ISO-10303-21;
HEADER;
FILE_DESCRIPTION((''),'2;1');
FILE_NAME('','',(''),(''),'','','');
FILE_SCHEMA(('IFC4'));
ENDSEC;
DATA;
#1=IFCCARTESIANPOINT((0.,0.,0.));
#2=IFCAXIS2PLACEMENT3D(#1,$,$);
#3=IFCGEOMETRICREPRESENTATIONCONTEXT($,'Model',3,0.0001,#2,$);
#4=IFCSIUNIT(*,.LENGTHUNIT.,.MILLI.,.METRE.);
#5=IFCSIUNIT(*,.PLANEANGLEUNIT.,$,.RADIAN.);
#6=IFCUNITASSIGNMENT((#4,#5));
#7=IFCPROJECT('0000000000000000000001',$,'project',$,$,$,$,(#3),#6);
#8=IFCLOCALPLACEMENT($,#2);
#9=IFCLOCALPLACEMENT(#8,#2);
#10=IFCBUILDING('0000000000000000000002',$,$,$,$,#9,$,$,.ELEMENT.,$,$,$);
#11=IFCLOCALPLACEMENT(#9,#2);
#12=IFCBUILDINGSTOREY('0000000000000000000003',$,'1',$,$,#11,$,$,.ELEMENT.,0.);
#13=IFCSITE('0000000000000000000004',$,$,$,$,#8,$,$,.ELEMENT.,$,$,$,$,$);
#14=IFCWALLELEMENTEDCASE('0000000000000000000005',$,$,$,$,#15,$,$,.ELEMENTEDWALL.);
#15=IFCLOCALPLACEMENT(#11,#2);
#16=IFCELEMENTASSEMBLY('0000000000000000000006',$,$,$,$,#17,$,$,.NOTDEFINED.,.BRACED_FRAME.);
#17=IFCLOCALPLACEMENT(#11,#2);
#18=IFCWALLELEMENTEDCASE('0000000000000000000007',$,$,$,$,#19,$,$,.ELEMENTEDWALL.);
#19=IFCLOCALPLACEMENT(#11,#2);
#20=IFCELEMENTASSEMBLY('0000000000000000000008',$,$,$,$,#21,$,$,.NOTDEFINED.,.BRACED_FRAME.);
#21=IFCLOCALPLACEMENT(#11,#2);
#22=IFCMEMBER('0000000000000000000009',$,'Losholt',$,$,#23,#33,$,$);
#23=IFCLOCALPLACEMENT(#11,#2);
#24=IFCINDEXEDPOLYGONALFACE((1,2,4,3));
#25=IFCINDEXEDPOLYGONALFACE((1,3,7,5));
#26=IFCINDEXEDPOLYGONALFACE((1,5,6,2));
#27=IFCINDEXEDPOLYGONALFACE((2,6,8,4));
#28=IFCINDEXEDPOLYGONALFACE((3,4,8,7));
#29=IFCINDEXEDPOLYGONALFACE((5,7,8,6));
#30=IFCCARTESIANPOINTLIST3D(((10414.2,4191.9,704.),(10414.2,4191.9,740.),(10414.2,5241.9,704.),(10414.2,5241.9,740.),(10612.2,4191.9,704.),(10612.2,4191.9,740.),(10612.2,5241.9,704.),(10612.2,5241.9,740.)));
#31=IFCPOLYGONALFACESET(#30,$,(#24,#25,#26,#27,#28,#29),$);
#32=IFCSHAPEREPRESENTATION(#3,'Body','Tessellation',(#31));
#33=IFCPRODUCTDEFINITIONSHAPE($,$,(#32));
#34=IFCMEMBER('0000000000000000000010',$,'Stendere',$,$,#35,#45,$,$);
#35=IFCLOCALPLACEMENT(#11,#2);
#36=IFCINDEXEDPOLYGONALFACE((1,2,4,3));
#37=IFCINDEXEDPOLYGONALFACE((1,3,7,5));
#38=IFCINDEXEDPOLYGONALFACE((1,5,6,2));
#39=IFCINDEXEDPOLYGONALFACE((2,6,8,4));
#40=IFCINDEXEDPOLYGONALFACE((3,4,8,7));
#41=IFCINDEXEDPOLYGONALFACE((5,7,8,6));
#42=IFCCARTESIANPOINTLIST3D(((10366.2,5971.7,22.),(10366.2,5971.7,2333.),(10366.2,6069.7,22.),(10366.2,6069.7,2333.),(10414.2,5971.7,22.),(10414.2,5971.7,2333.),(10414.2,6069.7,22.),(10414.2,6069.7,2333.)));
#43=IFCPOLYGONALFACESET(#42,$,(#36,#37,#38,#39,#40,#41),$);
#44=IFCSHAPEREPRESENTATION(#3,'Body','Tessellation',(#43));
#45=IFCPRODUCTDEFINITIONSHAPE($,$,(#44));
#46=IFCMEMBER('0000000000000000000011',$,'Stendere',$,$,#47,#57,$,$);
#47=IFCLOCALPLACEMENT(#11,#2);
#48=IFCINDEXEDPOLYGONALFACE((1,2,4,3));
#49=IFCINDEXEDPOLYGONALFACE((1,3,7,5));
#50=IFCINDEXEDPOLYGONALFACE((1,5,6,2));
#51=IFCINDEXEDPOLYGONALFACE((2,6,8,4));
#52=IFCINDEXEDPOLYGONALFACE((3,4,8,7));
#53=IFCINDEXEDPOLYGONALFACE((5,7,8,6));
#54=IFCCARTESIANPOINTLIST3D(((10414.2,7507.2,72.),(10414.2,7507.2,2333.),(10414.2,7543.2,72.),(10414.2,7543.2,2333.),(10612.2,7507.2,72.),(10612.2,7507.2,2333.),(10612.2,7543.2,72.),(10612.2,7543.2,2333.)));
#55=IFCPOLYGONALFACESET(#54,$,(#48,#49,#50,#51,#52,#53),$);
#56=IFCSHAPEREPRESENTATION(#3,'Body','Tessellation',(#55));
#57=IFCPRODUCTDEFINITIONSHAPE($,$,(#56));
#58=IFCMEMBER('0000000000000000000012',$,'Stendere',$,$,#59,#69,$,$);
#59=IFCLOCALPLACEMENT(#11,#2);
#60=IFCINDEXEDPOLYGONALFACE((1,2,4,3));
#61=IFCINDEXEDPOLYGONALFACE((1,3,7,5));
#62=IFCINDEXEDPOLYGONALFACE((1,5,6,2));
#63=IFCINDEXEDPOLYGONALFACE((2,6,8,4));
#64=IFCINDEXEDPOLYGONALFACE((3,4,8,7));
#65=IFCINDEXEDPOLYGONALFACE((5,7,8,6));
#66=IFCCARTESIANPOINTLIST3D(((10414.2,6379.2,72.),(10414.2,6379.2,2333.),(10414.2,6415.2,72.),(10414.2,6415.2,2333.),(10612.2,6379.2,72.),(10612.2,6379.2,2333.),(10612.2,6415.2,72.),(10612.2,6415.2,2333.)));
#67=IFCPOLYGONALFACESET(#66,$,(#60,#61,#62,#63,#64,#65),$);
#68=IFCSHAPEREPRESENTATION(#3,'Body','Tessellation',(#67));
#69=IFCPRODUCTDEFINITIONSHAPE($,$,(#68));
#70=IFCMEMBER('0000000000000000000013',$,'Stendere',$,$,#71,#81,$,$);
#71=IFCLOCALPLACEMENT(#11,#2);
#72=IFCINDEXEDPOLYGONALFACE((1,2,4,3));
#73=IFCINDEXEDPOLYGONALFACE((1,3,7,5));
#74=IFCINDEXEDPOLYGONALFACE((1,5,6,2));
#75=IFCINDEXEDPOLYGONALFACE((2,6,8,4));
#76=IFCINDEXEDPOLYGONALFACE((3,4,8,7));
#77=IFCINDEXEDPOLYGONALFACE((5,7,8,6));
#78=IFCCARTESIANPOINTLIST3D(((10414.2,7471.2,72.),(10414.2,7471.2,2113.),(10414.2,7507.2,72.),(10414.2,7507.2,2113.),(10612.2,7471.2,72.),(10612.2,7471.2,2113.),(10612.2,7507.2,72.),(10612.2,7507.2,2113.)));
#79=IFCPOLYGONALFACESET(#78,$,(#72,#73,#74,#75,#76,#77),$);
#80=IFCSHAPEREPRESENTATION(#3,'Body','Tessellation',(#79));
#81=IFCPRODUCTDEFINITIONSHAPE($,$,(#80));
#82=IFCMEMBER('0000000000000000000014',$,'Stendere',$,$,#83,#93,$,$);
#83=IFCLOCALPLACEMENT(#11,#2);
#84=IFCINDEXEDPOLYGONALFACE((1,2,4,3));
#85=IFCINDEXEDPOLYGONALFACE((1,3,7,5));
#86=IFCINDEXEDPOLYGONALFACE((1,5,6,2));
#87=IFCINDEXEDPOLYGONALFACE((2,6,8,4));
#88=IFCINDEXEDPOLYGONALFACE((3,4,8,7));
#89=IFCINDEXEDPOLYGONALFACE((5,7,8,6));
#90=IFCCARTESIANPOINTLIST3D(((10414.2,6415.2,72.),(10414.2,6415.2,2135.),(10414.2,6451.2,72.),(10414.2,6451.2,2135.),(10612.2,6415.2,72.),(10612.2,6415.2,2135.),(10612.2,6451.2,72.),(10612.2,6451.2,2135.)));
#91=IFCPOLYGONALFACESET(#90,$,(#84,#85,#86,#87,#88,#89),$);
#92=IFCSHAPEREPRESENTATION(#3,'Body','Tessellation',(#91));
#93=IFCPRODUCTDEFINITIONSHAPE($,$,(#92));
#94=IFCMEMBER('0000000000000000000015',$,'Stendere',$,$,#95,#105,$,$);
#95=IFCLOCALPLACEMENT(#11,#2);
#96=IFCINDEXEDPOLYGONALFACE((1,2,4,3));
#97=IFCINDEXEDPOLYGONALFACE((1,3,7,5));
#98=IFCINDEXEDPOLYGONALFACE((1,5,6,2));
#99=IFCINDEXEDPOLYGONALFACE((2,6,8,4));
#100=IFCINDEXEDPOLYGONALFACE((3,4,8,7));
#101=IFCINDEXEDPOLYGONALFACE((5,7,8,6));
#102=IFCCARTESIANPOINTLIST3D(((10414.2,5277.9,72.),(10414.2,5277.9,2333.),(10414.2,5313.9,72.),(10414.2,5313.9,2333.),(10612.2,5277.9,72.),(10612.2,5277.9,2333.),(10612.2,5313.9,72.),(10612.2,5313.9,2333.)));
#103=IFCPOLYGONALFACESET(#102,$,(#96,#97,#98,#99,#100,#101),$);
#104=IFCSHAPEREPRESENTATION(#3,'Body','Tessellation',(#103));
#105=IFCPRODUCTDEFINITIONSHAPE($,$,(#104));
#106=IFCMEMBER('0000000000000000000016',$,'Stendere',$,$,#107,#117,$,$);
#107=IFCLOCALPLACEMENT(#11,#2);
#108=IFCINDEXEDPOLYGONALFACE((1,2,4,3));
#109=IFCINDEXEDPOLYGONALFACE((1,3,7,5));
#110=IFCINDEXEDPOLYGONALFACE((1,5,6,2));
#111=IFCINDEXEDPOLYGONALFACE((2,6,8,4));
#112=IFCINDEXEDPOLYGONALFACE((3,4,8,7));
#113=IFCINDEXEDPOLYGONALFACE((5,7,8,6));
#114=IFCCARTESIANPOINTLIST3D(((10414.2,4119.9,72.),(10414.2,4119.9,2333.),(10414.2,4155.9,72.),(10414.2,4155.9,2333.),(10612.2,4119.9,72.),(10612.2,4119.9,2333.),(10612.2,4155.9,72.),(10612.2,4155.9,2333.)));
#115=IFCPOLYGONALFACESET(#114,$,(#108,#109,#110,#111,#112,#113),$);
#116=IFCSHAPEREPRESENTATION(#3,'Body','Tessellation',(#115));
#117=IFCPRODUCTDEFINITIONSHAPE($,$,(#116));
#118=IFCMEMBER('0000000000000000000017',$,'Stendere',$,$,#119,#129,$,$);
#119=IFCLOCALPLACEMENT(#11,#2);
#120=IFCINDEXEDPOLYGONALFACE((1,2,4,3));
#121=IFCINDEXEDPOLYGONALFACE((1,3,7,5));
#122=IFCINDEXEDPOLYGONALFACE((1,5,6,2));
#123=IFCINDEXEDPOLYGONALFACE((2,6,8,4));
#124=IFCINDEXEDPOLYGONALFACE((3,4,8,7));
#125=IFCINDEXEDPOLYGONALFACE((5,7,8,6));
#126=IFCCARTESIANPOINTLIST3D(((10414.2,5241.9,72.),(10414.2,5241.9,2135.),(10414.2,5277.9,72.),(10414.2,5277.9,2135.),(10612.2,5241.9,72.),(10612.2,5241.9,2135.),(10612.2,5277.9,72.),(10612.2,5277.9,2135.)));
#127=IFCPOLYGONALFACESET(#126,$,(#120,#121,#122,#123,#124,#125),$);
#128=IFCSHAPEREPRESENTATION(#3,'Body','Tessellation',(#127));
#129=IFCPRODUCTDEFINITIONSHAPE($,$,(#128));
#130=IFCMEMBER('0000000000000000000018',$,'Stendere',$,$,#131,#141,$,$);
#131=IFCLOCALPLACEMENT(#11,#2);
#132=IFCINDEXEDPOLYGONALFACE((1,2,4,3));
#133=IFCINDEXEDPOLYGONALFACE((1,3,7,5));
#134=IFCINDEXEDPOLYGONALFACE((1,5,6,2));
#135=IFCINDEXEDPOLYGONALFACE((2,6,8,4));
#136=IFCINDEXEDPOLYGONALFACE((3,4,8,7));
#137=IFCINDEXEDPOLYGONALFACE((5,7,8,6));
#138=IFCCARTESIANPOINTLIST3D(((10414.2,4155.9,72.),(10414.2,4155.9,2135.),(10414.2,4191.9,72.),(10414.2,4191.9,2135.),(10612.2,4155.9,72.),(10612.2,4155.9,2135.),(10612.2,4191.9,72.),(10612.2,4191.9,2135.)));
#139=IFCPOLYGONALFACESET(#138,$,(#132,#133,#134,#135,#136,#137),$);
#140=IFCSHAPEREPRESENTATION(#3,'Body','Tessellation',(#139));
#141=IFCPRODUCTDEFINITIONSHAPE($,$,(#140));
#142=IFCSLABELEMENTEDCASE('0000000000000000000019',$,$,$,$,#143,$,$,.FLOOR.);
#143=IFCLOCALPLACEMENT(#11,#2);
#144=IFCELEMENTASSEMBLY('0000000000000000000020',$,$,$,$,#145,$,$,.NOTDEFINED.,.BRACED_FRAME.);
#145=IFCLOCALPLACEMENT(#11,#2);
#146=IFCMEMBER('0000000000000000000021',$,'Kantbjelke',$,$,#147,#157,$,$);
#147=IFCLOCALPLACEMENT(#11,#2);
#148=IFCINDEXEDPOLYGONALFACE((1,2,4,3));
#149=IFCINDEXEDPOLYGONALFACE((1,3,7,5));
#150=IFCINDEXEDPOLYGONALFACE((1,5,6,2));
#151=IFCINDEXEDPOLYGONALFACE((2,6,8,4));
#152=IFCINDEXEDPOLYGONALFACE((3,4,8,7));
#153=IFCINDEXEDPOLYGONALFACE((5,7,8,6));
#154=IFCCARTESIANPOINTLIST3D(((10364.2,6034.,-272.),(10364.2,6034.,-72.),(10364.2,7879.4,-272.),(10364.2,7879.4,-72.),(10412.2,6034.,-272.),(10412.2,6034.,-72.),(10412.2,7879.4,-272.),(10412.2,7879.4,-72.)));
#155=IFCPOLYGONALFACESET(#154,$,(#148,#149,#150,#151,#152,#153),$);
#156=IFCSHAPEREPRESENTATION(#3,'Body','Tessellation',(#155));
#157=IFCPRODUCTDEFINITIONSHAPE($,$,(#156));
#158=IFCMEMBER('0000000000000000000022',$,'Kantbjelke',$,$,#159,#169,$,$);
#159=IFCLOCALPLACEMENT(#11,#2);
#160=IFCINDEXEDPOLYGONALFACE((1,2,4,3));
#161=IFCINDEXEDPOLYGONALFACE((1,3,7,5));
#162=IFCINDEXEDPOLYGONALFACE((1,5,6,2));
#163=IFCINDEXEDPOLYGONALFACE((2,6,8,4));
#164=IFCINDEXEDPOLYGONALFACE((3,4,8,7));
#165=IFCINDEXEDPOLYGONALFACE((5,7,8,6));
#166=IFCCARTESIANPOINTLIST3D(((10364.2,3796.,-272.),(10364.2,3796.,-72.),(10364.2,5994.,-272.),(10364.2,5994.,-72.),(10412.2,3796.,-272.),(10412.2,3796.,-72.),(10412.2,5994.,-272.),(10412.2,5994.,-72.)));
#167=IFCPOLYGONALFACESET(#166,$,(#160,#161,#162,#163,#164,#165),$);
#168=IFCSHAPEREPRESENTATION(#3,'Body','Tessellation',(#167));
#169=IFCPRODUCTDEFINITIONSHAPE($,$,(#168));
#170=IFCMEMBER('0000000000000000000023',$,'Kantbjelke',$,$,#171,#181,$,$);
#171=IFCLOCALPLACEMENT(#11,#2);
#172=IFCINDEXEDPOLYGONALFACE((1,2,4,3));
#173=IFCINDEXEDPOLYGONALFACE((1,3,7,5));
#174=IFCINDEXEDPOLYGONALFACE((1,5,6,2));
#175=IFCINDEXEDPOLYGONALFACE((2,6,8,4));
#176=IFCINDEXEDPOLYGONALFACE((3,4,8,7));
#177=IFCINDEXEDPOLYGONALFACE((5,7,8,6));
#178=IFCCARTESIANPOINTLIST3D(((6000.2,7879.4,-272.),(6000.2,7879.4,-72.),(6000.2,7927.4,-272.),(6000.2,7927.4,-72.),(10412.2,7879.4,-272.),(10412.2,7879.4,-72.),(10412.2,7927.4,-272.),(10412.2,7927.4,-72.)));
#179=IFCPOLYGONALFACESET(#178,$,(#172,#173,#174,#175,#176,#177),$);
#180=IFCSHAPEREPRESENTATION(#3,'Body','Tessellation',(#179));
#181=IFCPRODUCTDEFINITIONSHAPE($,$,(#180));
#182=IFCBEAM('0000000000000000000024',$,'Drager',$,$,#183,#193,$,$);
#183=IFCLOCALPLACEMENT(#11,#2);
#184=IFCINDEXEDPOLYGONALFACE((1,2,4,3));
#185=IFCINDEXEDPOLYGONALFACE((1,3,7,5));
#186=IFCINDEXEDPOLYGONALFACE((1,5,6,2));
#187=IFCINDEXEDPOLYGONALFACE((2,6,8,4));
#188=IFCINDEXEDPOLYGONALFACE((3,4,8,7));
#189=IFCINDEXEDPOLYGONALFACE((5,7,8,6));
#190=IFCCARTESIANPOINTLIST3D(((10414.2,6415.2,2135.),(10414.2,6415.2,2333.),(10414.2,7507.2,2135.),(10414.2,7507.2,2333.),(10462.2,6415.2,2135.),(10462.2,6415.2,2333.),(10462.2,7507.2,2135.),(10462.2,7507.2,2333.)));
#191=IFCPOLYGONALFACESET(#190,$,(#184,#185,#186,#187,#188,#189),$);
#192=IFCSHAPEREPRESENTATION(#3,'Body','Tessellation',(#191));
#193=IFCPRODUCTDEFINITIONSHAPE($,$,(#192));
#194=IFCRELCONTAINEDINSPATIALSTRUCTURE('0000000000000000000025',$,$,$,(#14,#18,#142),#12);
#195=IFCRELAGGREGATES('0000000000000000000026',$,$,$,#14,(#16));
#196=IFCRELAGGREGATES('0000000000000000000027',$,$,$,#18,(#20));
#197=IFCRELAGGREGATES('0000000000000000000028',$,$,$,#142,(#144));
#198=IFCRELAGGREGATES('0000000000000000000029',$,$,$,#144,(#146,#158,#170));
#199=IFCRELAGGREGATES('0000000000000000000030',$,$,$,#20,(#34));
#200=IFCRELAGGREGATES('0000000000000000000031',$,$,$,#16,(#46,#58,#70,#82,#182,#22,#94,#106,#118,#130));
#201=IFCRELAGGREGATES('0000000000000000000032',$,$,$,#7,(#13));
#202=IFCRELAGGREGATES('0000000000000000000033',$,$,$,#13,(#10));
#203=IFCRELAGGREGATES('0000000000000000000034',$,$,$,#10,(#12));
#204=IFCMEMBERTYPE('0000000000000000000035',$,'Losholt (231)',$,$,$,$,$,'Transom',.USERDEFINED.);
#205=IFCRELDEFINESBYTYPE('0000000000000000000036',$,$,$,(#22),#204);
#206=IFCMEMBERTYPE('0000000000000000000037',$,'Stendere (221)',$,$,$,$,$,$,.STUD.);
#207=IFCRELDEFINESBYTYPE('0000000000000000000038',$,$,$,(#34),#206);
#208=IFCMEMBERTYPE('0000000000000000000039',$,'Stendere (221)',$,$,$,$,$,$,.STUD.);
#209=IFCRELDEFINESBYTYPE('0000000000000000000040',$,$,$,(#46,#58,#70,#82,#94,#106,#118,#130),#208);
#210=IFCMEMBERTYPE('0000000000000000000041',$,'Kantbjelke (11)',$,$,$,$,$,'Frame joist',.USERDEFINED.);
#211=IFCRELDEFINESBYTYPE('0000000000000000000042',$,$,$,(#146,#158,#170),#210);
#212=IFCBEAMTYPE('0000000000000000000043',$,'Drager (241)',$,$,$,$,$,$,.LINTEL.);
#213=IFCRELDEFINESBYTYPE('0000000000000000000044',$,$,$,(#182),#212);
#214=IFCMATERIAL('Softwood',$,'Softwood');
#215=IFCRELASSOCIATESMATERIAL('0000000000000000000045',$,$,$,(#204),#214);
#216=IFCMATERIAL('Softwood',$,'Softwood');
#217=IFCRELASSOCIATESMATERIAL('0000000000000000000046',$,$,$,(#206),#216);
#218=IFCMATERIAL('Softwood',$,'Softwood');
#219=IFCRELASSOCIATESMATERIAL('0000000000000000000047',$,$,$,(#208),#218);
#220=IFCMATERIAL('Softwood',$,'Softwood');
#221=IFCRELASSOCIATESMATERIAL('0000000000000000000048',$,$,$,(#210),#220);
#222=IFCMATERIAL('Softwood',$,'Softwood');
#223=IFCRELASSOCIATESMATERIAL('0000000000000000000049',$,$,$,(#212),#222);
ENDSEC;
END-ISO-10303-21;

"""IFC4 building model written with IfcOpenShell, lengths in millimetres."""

from ifc_helpers import new_model, si_unit, frame, origin, place, context, project, spatial, rectangle, extrude, material, material_profile, profile_set, type_object, element, aggregate, save


model = new_model("IFC4")

# Units and contexts
model_context = context("Model", 3, precision=0.0001, world=origin())
ifc_project = project(units=[si_unit("LENGTHUNIT", "METRE", prefix="MILLI"), si_unit("PLANEANGLEUNIT", "RADIAN")], contexts=[model_context])

# Site, building, storey
site_placement = place(None, origin())
site = spatial("IfcSite", under=ifc_project, at=site_placement, CompositionType="ELEMENT")
building_placement = place(site_placement, origin())
building = spatial("IfcBuilding", under=site, at=building_placement, CompositionType="ELEMENT")
storey_placement = place(building_placement, origin())
storey = spatial("IfcBuildingStorey", under=building, at=storey_placement, Name="1", CompositionType="ELEMENT", Elevation=0.0)

# Wall, element assembly
wall_1_placement = place(storey_placement, frame((10414.2, 3748.0, 0.0), z_axis=(1.0, 0.0, 0.0), x_axis=(0.0, 1.0, 0.0)))
wall_1 = element("IfcWallElementedCase", 1, at=wall_1_placement, inside=storey, PredefinedType="ELEMENTEDWALL")
assembly_1_placement = place(wall_1_placement, origin())
assembly_1 = element("IfcElementAssembly", 2, at=assembly_1_placement, AssemblyPlace="NOTDEFINED", PredefinedType="BRACED_FRAME")
aggregate(wall_1, [assembly_1])

# Wall, element assembly
wall_2_placement = place(storey_placement, frame((10414.2, 5971.7, -50.0), z_axis=(0.0, 1.0, 0.0), x_axis=(-1.0, 0.0, 0.0)))
wall_2 = element("IfcWallElementedCase", 3, at=wall_2_placement, inside=storey, PredefinedType="ELEMENTEDWALL")
assembly_2_placement = place(wall_2_placement, origin())
assembly_2 = element("IfcElementAssembly", 4, at=assembly_2_placement, AssemblyPlace="NOTDEFINED", PredefinedType="BRACED_FRAME")
aggregate(wall_2, [assembly_2])

# Members
ifc_material_1 = material(Name="Softwood", Category="Softwood")
ifc_material_profile_1 = material_profile(ifc_material_1, rectangle(XDim=36.0, YDim=198.0), Name="Losholt (231)")
ifc_profile_set_1 = profile_set([ifc_material_profile_1])
member_type_1 = type_object("IfcMemberType", Name="Losholt (231)", ElementType="Transom", PredefinedType="USERDEFINED", material=ifc_profile_set_1)
member_1_placement = place(assembly_1_placement, frame((443.9, 722.0, 0.0), z_axis=(1.0, 0.0, 0.0), x_axis=(0.0, 1.0, 0.0)))
member_1 = element("IfcMember", 5, at=member_1_placement, type_object=member_type_1, Name="Losholt", context=model_context, shape_type="SweptSolid", body=[
    extrude(rectangle(XDim=36.0, YDim=198.0), frame((0.0, 99.0, 0.0)), (0.0, 0.0, 1.0), 1050.0),
])
ifc_material_2 = material(Name="Softwood", Category="Softwood")
ifc_material_profile_2 = material_profile(ifc_material_2, rectangle(XDim=48.0, YDim=98.0), Name="Stendere (221)")
ifc_profile_set_2 = profile_set([ifc_material_profile_2])
member_type_2 = type_object("IfcMemberType", Name="Stendere (221)", PredefinedType="STUD", material=ifc_profile_set_2)
member_2_placement = place(assembly_2_placement, frame((24.0, 72.0, 0.0), z_axis=(0.0, 1.0, 0.0), x_axis=(-1.0, 0.0, 0.0)))
member_2 = element("IfcMember", 6, at=member_2_placement, type_object=member_type_2, Name="Stendere", context=model_context, shape_type="SweptSolid", body=[
    extrude(rectangle(XDim=48.0, YDim=98.0), frame((0.0, 49.0, 0.0)), (0.0, 0.0, 1.0), 2311.0),
])
ifc_material_3 = material(Name="Softwood", Category="Softwood")
ifc_material_profile_3 = material_profile(ifc_material_3, rectangle(XDim=36.0, YDim=198.0), Name="Stendere (221)")
ifc_profile_set_3 = profile_set([ifc_material_profile_3])
member_type_3 = type_object("IfcMemberType", Name="Stendere (221)", PredefinedType="STUD", material=ifc_profile_set_3)
member_3_placement = place(assembly_1_placement, frame((3777.2, 72.0, 0.0), z_axis=(0.0, 1.0, 0.0), x_axis=(-1.0, 0.0, 0.0)))
member_3 = element("IfcMember", 7, at=member_3_placement, type_object=member_type_3, Name="Stendere", context=model_context, shape_type="SweptSolid", body=[
    extrude(rectangle(XDim=36.0, YDim=198.0), frame((0.0, 99.0, 0.0)), (0.0, 0.0, 1.0), 2261.0),
])
member_4_placement = place(assembly_1_placement, frame((2649.2, 72.0, 0.0), z_axis=(0.0, 1.0, 0.0), x_axis=(-1.0, 0.0, 0.0)))
member_4 = element("IfcMember", 8, at=member_4_placement, type_object=member_type_3, Name="Stendere", context=model_context, shape_type="SweptSolid", body=[
    extrude(rectangle(XDim=36.0, YDim=198.0), frame((0.0, 99.0, 0.0)), (0.0, 0.0, 1.0), 2261.0),
])
member_5_placement = place(assembly_1_placement, frame((3741.2, 72.0, 0.0), z_axis=(0.0, 1.0, 0.0), x_axis=(-1.0, 0.0, 0.0)))
member_5 = element("IfcMember", 9, at=member_5_placement, type_object=member_type_3, Name="Stendere", context=model_context, shape_type="SweptSolid", body=[
    extrude(rectangle(XDim=36.0, YDim=198.0), frame((0.0, 99.0, 0.0)), (0.0, 0.0, 1.0), 2041.0),
])
member_6_placement = place(assembly_1_placement, frame((2685.2, 72.0, 0.0), z_axis=(0.0, 1.0, 0.0), x_axis=(-1.0, 0.0, 0.0)))
member_6 = element("IfcMember", 10, at=member_6_placement, type_object=member_type_3, Name="Stendere", context=model_context, shape_type="SweptSolid", body=[
    extrude(rectangle(XDim=36.0, YDim=198.0), frame((0.0, 99.0, 0.0)), (0.0, 0.0, 1.0), 2063.0),
])
member_7_placement = place(assembly_1_placement, frame((1547.9, 72.0, 0.0), z_axis=(0.0, 1.0, 0.0), x_axis=(-1.0, 0.0, 0.0)))
member_7 = element("IfcMember", 11, at=member_7_placement, type_object=member_type_3, Name="Stendere", context=model_context, shape_type="SweptSolid", body=[
    extrude(rectangle(XDim=36.0, YDim=198.0), frame((0.0, 99.0, 0.0)), (0.0, 0.0, 1.0), 2261.0),
])
member_8_placement = place(assembly_1_placement, frame((389.9, 72.0, 0.0), z_axis=(0.0, 1.0, 0.0), x_axis=(-1.0, 0.0, 0.0)))
member_8 = element("IfcMember", 12, at=member_8_placement, type_object=member_type_3, Name="Stendere", context=model_context, shape_type="SweptSolid", body=[
    extrude(rectangle(XDim=36.0, YDim=198.0), frame((0.0, 99.0, 0.0)), (0.0, 0.0, 1.0), 2261.0),
])
member_9_placement = place(assembly_1_placement, frame((1511.9, 72.0, 0.0), z_axis=(0.0, 1.0, 0.0), x_axis=(-1.0, 0.0, 0.0)))
member_9 = element("IfcMember", 13, at=member_9_placement, type_object=member_type_3, Name="Stendere", context=model_context, shape_type="SweptSolid", body=[
    extrude(rectangle(XDim=36.0, YDim=198.0), frame((0.0, 99.0, 0.0)), (0.0, 0.0, 1.0), 2063.0),
])
member_10_placement = place(assembly_1_placement, frame((425.9, 72.0, 0.0), z_axis=(0.0, 1.0, 0.0), x_axis=(-1.0, 0.0, 0.0)))
member_10 = element("IfcMember", 14, at=member_10_placement, type_object=member_type_3, Name="Stendere", context=model_context, shape_type="SweptSolid", body=[
    extrude(rectangle(XDim=36.0, YDim=198.0), frame((0.0, 99.0, 0.0)), (0.0, 0.0, 1.0), 2063.0),
])

# Slab, element assembly, members
slab_placement = place(storey_placement, origin())
slab = element("IfcSlabElementedCase", 15, at=slab_placement, inside=storey, PredefinedType="FLOOR")
assembly_3_placement = place(slab_placement, frame((0.0, 0.0, -225.0)))
assembly_3 = element("IfcElementAssembly", 16, at=assembly_3_placement, AssemblyPlace="NOTDEFINED", PredefinedType="BRACED_FRAME")
aggregate(slab, [assembly_3])
ifc_material_4 = material(Name="Softwood", Category="Softwood")
ifc_material_profile_4 = material_profile(ifc_material_4, rectangle(XDim=48.0, YDim=200.0), Name="Kantbjelke (11)")
ifc_profile_set_4 = profile_set([ifc_material_profile_4])
member_type_4 = type_object("IfcMemberType", Name="Kantbjelke (11)", ElementType="Frame joist", PredefinedType="USERDEFINED", material=ifc_profile_set_4)
member_11_placement = place(assembly_3_placement, frame((10388.2, 6034.0, -47.0), z_axis=(0.0, 1.0, 0.0), x_axis=(-1.0, 0.0, 0.0)))
member_11 = element("IfcMember", 17, at=member_11_placement, type_object=member_type_4, Name="Kantbjelke", context=model_context, shape_type="SweptSolid", body=[
    extrude(rectangle(XDim=48.0, YDim=200.0), frame((0.0, 100.0, 0.0)), (0.0, 0.0, 1.0), 1845.4),
])
member_12_placement = place(assembly_3_placement, frame((10388.2, 3796.0, -47.0), z_axis=(0.0, 1.0, 0.0), x_axis=(-1.0, 0.0, 0.0)))
member_12 = element("IfcMember", 18, at=member_12_placement, type_object=member_type_4, Name="Kantbjelke", context=model_context, shape_type="SweptSolid", body=[
    extrude(rectangle(XDim=48.0, YDim=200.0), frame((0.0, 100.0, 0.0)), (0.0, 0.0, 1.0), 2198.0),
])
member_13_placement = place(assembly_3_placement, frame((10412.2, 7903.4, -47.0), z_axis=(-1.0, 0.0, 0.0), x_axis=(0.0, -1.0, 0.0)))
member_13 = element("IfcMember", 19, at=member_13_placement, type_object=member_type_4, Name="Kantbjelke", context=model_context, shape_type="SweptSolid", body=[
    extrude(rectangle(XDim=48.0, YDim=200.0), frame((0.0, 100.0, 0.0)), (0.0, 0.0, 1.0), 4412.0),
])
aggregate(assembly_3, [member_11, member_12, member_13])

# Beam
ifc_material_5 = material(Name="Softwood", Category="Softwood")
ifc_material_profile_5 = material_profile(ifc_material_5, rectangle(XDim=198.0, YDim=48.0), Name="Drager (241)")
ifc_profile_set_5 = profile_set([ifc_material_profile_5])
beam_type = type_object("IfcBeamType", Name="Drager (241)", PredefinedType="LINTEL", material=ifc_profile_set_5)
beam_1_placement = place(assembly_1_placement, frame((2667.2, 2234.0, 0.0), z_axis=(1.0, 0.0, 0.0), x_axis=(0.0, 1.0, 0.0)))
beam_1 = element("IfcBeam", 20, at=beam_1_placement, type_object=beam_type, Name="Drager", context=model_context, shape_type="SweptSolid", body=[
    extrude(rectangle(XDim=198.0, YDim=48.0), frame((0.0, 24.0, 0.0)), (0.0, 0.0, 1.0), 1092.0),
])

aggregate(assembly_2, [member_2])
aggregate(assembly_1, [member_3, member_4, member_5, member_6, beam_1, member_1, member_7, member_8, member_9, member_10])

save(model, "model.ifc")
